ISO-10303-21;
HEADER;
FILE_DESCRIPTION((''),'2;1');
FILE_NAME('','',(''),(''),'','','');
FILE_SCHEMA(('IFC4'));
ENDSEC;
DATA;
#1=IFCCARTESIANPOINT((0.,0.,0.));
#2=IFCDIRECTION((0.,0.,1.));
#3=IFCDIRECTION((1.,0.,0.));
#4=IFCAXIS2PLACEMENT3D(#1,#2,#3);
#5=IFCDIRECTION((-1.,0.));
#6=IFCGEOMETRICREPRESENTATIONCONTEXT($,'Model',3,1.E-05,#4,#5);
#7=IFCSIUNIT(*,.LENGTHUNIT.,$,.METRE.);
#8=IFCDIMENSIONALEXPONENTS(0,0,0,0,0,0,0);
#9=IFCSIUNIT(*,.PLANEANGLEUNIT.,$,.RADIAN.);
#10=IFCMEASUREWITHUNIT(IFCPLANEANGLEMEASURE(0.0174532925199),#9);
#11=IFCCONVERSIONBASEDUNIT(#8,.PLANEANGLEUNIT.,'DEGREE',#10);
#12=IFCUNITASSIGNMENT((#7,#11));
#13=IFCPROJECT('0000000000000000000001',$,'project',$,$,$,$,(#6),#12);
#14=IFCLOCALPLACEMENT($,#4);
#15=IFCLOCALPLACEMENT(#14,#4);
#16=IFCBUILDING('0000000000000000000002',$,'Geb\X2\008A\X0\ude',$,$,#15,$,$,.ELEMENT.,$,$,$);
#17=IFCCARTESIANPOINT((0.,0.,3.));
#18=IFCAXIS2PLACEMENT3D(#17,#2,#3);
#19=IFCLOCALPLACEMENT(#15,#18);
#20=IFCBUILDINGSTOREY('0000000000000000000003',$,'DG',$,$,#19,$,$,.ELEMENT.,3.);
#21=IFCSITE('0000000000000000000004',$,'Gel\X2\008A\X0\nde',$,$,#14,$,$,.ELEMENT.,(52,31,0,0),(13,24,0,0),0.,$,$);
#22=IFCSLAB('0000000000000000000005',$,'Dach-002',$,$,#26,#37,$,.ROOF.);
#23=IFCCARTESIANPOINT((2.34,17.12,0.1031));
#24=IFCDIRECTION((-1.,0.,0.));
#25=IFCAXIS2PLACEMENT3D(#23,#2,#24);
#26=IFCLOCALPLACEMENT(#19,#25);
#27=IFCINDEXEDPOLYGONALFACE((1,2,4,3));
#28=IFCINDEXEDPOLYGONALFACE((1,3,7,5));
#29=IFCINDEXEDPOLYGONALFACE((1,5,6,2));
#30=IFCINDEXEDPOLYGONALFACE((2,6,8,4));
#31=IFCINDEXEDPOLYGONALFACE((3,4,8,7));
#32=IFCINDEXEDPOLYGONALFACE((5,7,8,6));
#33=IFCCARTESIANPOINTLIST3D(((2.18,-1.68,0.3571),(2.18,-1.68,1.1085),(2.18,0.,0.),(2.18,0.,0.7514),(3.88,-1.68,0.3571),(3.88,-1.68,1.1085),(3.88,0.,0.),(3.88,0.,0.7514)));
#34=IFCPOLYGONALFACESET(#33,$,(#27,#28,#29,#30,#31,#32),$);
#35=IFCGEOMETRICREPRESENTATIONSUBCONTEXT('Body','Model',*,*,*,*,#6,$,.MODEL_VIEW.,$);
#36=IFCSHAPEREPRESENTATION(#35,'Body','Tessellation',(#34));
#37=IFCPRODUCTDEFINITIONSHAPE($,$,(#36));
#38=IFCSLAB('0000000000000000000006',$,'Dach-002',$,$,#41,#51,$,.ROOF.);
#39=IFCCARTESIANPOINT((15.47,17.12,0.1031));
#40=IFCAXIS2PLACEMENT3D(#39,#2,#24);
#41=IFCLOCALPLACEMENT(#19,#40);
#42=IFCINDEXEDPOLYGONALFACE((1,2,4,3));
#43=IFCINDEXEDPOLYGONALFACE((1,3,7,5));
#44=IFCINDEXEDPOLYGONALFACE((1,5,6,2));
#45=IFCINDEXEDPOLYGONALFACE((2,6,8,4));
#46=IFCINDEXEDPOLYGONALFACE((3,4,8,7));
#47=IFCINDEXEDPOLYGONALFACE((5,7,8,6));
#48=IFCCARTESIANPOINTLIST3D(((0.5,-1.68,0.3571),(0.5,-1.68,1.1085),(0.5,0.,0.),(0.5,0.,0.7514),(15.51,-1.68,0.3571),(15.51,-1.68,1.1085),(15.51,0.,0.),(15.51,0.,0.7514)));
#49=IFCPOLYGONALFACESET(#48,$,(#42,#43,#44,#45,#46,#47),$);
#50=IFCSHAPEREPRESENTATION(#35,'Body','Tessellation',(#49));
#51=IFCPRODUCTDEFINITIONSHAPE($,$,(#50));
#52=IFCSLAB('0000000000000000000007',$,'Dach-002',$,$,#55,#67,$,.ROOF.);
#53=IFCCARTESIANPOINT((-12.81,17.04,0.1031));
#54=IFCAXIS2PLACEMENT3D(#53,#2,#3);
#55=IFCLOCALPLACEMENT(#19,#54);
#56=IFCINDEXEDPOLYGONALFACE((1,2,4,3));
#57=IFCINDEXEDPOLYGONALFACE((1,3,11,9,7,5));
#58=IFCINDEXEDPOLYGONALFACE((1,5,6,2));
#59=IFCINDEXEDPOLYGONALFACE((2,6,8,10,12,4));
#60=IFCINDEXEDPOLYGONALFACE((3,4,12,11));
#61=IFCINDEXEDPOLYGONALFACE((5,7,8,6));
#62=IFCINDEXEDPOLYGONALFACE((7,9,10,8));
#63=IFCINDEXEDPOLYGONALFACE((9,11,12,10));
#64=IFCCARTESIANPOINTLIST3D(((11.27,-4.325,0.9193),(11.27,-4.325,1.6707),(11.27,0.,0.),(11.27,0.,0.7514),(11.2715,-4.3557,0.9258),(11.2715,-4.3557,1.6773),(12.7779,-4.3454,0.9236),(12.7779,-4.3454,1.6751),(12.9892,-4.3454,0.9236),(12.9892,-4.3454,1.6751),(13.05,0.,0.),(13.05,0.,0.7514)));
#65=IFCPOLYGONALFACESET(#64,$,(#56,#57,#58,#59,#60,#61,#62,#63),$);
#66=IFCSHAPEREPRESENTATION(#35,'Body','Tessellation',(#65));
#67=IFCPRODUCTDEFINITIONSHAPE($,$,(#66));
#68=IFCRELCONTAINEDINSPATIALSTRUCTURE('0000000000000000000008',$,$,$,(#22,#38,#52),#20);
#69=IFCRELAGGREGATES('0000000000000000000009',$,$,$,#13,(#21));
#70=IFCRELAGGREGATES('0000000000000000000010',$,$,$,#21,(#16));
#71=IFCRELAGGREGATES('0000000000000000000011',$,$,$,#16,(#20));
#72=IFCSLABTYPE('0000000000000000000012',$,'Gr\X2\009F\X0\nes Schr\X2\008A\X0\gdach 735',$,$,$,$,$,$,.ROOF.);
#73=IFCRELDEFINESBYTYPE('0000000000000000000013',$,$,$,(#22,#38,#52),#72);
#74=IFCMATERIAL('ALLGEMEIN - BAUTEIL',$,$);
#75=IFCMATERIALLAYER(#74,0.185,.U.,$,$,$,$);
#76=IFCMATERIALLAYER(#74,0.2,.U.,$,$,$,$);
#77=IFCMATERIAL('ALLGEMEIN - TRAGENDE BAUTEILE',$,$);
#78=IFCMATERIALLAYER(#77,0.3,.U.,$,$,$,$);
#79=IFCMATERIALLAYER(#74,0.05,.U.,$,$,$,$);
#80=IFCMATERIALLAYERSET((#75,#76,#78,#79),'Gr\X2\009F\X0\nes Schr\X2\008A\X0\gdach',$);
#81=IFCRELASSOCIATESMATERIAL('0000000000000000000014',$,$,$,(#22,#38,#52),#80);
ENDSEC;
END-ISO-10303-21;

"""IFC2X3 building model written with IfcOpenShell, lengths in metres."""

from ifc_helpers import new_model, entity, si_unit, converted_unit, direction, frame, origin_with_axes, place, context, subcontext, project, spatial, polyline, outline, extrude, material, layer, layer_set, layer_usage, type_object, element, save


model = new_model("IFC2X3")

# Units and contexts
model_context = context("Model", 3, precision=1e-05, world=origin_with_axes(), true_north=direction((-1.0, 0.0)))
body_context = subcontext(model_context, "Body", "Model", "MODEL_VIEW")
ifc_project = project(units=[si_unit("LENGTHUNIT", "METRE"), converted_unit("PLANEANGLEUNIT", "DEGREE", entity("IfcPlaneAngleMeasure", 0.0174532925199), si_unit("PLANEANGLEUNIT", "RADIAN"), dimensions=[0, 0, 0, 0, 0, 0, 0])], contexts=[model_context])

# Site, building, storey
site_placement = place(None, origin_with_axes())
site = spatial("IfcSite", under=ifc_project, at=site_placement, Name="Gel\u008ande", CompositionType="ELEMENT", RefLatitude=(52, 31, 0, 0), RefLongitude=(13, 24, 0, 0), RefElevation=0.0)
building_placement = place(site_placement, origin_with_axes())
building = spatial("IfcBuilding", under=site, at=building_placement, Name="Geb\u008aude", CompositionType="ELEMENT")
storey_placement = place(building_placement, frame((0.0, 0.0, 3.0), z_axis=(0.0, 0.0, 1.0), x_axis=(1.0, 0.0, 0.0)))
storey = spatial("IfcBuildingStorey", under=building, at=storey_placement, Name="DG", CompositionType="ELEMENT", Elevation=3.0)

# Slabs
ifc_material_1 = material(Name="ALLGEMEIN - BAUTEIL")
ifc_layer_1 = layer(ifc_material_1, 0.185, ventilated="UNKNOWN")
ifc_layer_2 = layer(ifc_material_1, 0.2, ventilated="UNKNOWN")
ifc_material_2 = material(Name="ALLGEMEIN - TRAGENDE BAUTEILE")
ifc_layer_3 = layer(ifc_material_2, 0.3, ventilated="UNKNOWN")
ifc_layer_4 = layer(ifc_material_1, 0.05, ventilated="UNKNOWN")
ifc_layer_set = layer_set([ifc_layer_1, ifc_layer_2, ifc_layer_3, ifc_layer_4], Name="Gr\u009fnes Schr\u008agdach")
ifc_layer_usage_1 = layer_usage(ifc_layer_set, "AXIS3", "NEGATIVE", 0.735)
slab_type = type_object("IfcSlabType", Name="Gr\u009fnes Schr\u008agdach 735", PredefinedType="ROOF")
slab_1_placement = place(storey_placement, frame((2.34, 17.12, 0.1031), z_axis=(0.0, 0.0, 1.0), x_axis=(-1.0, 0.0, 0.0)))
element("IfcSlab", 1, at=slab_1_placement, inside=storey, type_object=slab_type, material=ifc_layer_usage_1, Name="Dach-002", PredefinedType="ROOF", context=body_context, shape_type="SweptSolid", body=[
    extrude(outline(polyline([(2.18, 0.0), (2.18, -1.7175), (3.88, -1.7175), (3.88, 0.0), (2.18, 0.0)])), frame((0.0, 0.0, 0.0), z_axis=(0.0, 0.207912, 0.978148), x_axis=(1.0, 0.0, 0.0)), (0.0, -0.207912, 0.978148), 0.7514),
])
ifc_layer_usage_2 = layer_usage(ifc_layer_set, "AXIS3", "NEGATIVE", 0.735)
slab_2_placement = place(storey_placement, frame((15.47, 17.12, 0.1031), z_axis=(0.0, 0.0, 1.0), x_axis=(-1.0, 0.0, 0.0)))
element("IfcSlab", 2, at=slab_2_placement, inside=storey, type_object=slab_type, material=ifc_layer_usage_2, Name="Dach-002", PredefinedType="ROOF", context=body_context, shape_type="SweptSolid", body=[
    extrude(outline(polyline([(15.51, -1.7175), (15.51, 0.0), (0.5, 0.0), (0.5, -1.7175), (15.51, -1.7175)])), frame((0.0, 0.0, 0.0), z_axis=(0.0, 0.207912, 0.978148), x_axis=(1.0, 0.0, 0.0)), (0.0, -0.207912, 0.978148), 0.7514),
])
ifc_layer_usage_3 = layer_usage(ifc_layer_set, "AXIS3", "NEGATIVE", 0.735)
slab_3_placement = place(storey_placement, frame((-12.81, 17.04, 0.1031), z_axis=(0.0, 0.0, 1.0), x_axis=(1.0, 0.0, 0.0)))
element("IfcSlab", 3, at=slab_3_placement, inside=storey, type_object=slab_type, material=ifc_layer_usage_3, Name="Dach-002", PredefinedType="ROOF", context=body_context, shape_type="SweptSolid", body=[
    extrude(outline(polyline([(13.05, 0.0), (11.27, 0.0), (11.27, -4.4216), (11.2715, -4.453), (12.7779, -4.4425), (12.9892, -4.4425), (13.05, 0.0)])), frame((0.0, 0.0, 0.0), z_axis=(0.0, 0.207912, 0.978148), x_axis=(1.0, 0.0, 0.0)), (0.0, -0.207912, 0.978148), 0.7514),
])

save(model, "model.ifc")
